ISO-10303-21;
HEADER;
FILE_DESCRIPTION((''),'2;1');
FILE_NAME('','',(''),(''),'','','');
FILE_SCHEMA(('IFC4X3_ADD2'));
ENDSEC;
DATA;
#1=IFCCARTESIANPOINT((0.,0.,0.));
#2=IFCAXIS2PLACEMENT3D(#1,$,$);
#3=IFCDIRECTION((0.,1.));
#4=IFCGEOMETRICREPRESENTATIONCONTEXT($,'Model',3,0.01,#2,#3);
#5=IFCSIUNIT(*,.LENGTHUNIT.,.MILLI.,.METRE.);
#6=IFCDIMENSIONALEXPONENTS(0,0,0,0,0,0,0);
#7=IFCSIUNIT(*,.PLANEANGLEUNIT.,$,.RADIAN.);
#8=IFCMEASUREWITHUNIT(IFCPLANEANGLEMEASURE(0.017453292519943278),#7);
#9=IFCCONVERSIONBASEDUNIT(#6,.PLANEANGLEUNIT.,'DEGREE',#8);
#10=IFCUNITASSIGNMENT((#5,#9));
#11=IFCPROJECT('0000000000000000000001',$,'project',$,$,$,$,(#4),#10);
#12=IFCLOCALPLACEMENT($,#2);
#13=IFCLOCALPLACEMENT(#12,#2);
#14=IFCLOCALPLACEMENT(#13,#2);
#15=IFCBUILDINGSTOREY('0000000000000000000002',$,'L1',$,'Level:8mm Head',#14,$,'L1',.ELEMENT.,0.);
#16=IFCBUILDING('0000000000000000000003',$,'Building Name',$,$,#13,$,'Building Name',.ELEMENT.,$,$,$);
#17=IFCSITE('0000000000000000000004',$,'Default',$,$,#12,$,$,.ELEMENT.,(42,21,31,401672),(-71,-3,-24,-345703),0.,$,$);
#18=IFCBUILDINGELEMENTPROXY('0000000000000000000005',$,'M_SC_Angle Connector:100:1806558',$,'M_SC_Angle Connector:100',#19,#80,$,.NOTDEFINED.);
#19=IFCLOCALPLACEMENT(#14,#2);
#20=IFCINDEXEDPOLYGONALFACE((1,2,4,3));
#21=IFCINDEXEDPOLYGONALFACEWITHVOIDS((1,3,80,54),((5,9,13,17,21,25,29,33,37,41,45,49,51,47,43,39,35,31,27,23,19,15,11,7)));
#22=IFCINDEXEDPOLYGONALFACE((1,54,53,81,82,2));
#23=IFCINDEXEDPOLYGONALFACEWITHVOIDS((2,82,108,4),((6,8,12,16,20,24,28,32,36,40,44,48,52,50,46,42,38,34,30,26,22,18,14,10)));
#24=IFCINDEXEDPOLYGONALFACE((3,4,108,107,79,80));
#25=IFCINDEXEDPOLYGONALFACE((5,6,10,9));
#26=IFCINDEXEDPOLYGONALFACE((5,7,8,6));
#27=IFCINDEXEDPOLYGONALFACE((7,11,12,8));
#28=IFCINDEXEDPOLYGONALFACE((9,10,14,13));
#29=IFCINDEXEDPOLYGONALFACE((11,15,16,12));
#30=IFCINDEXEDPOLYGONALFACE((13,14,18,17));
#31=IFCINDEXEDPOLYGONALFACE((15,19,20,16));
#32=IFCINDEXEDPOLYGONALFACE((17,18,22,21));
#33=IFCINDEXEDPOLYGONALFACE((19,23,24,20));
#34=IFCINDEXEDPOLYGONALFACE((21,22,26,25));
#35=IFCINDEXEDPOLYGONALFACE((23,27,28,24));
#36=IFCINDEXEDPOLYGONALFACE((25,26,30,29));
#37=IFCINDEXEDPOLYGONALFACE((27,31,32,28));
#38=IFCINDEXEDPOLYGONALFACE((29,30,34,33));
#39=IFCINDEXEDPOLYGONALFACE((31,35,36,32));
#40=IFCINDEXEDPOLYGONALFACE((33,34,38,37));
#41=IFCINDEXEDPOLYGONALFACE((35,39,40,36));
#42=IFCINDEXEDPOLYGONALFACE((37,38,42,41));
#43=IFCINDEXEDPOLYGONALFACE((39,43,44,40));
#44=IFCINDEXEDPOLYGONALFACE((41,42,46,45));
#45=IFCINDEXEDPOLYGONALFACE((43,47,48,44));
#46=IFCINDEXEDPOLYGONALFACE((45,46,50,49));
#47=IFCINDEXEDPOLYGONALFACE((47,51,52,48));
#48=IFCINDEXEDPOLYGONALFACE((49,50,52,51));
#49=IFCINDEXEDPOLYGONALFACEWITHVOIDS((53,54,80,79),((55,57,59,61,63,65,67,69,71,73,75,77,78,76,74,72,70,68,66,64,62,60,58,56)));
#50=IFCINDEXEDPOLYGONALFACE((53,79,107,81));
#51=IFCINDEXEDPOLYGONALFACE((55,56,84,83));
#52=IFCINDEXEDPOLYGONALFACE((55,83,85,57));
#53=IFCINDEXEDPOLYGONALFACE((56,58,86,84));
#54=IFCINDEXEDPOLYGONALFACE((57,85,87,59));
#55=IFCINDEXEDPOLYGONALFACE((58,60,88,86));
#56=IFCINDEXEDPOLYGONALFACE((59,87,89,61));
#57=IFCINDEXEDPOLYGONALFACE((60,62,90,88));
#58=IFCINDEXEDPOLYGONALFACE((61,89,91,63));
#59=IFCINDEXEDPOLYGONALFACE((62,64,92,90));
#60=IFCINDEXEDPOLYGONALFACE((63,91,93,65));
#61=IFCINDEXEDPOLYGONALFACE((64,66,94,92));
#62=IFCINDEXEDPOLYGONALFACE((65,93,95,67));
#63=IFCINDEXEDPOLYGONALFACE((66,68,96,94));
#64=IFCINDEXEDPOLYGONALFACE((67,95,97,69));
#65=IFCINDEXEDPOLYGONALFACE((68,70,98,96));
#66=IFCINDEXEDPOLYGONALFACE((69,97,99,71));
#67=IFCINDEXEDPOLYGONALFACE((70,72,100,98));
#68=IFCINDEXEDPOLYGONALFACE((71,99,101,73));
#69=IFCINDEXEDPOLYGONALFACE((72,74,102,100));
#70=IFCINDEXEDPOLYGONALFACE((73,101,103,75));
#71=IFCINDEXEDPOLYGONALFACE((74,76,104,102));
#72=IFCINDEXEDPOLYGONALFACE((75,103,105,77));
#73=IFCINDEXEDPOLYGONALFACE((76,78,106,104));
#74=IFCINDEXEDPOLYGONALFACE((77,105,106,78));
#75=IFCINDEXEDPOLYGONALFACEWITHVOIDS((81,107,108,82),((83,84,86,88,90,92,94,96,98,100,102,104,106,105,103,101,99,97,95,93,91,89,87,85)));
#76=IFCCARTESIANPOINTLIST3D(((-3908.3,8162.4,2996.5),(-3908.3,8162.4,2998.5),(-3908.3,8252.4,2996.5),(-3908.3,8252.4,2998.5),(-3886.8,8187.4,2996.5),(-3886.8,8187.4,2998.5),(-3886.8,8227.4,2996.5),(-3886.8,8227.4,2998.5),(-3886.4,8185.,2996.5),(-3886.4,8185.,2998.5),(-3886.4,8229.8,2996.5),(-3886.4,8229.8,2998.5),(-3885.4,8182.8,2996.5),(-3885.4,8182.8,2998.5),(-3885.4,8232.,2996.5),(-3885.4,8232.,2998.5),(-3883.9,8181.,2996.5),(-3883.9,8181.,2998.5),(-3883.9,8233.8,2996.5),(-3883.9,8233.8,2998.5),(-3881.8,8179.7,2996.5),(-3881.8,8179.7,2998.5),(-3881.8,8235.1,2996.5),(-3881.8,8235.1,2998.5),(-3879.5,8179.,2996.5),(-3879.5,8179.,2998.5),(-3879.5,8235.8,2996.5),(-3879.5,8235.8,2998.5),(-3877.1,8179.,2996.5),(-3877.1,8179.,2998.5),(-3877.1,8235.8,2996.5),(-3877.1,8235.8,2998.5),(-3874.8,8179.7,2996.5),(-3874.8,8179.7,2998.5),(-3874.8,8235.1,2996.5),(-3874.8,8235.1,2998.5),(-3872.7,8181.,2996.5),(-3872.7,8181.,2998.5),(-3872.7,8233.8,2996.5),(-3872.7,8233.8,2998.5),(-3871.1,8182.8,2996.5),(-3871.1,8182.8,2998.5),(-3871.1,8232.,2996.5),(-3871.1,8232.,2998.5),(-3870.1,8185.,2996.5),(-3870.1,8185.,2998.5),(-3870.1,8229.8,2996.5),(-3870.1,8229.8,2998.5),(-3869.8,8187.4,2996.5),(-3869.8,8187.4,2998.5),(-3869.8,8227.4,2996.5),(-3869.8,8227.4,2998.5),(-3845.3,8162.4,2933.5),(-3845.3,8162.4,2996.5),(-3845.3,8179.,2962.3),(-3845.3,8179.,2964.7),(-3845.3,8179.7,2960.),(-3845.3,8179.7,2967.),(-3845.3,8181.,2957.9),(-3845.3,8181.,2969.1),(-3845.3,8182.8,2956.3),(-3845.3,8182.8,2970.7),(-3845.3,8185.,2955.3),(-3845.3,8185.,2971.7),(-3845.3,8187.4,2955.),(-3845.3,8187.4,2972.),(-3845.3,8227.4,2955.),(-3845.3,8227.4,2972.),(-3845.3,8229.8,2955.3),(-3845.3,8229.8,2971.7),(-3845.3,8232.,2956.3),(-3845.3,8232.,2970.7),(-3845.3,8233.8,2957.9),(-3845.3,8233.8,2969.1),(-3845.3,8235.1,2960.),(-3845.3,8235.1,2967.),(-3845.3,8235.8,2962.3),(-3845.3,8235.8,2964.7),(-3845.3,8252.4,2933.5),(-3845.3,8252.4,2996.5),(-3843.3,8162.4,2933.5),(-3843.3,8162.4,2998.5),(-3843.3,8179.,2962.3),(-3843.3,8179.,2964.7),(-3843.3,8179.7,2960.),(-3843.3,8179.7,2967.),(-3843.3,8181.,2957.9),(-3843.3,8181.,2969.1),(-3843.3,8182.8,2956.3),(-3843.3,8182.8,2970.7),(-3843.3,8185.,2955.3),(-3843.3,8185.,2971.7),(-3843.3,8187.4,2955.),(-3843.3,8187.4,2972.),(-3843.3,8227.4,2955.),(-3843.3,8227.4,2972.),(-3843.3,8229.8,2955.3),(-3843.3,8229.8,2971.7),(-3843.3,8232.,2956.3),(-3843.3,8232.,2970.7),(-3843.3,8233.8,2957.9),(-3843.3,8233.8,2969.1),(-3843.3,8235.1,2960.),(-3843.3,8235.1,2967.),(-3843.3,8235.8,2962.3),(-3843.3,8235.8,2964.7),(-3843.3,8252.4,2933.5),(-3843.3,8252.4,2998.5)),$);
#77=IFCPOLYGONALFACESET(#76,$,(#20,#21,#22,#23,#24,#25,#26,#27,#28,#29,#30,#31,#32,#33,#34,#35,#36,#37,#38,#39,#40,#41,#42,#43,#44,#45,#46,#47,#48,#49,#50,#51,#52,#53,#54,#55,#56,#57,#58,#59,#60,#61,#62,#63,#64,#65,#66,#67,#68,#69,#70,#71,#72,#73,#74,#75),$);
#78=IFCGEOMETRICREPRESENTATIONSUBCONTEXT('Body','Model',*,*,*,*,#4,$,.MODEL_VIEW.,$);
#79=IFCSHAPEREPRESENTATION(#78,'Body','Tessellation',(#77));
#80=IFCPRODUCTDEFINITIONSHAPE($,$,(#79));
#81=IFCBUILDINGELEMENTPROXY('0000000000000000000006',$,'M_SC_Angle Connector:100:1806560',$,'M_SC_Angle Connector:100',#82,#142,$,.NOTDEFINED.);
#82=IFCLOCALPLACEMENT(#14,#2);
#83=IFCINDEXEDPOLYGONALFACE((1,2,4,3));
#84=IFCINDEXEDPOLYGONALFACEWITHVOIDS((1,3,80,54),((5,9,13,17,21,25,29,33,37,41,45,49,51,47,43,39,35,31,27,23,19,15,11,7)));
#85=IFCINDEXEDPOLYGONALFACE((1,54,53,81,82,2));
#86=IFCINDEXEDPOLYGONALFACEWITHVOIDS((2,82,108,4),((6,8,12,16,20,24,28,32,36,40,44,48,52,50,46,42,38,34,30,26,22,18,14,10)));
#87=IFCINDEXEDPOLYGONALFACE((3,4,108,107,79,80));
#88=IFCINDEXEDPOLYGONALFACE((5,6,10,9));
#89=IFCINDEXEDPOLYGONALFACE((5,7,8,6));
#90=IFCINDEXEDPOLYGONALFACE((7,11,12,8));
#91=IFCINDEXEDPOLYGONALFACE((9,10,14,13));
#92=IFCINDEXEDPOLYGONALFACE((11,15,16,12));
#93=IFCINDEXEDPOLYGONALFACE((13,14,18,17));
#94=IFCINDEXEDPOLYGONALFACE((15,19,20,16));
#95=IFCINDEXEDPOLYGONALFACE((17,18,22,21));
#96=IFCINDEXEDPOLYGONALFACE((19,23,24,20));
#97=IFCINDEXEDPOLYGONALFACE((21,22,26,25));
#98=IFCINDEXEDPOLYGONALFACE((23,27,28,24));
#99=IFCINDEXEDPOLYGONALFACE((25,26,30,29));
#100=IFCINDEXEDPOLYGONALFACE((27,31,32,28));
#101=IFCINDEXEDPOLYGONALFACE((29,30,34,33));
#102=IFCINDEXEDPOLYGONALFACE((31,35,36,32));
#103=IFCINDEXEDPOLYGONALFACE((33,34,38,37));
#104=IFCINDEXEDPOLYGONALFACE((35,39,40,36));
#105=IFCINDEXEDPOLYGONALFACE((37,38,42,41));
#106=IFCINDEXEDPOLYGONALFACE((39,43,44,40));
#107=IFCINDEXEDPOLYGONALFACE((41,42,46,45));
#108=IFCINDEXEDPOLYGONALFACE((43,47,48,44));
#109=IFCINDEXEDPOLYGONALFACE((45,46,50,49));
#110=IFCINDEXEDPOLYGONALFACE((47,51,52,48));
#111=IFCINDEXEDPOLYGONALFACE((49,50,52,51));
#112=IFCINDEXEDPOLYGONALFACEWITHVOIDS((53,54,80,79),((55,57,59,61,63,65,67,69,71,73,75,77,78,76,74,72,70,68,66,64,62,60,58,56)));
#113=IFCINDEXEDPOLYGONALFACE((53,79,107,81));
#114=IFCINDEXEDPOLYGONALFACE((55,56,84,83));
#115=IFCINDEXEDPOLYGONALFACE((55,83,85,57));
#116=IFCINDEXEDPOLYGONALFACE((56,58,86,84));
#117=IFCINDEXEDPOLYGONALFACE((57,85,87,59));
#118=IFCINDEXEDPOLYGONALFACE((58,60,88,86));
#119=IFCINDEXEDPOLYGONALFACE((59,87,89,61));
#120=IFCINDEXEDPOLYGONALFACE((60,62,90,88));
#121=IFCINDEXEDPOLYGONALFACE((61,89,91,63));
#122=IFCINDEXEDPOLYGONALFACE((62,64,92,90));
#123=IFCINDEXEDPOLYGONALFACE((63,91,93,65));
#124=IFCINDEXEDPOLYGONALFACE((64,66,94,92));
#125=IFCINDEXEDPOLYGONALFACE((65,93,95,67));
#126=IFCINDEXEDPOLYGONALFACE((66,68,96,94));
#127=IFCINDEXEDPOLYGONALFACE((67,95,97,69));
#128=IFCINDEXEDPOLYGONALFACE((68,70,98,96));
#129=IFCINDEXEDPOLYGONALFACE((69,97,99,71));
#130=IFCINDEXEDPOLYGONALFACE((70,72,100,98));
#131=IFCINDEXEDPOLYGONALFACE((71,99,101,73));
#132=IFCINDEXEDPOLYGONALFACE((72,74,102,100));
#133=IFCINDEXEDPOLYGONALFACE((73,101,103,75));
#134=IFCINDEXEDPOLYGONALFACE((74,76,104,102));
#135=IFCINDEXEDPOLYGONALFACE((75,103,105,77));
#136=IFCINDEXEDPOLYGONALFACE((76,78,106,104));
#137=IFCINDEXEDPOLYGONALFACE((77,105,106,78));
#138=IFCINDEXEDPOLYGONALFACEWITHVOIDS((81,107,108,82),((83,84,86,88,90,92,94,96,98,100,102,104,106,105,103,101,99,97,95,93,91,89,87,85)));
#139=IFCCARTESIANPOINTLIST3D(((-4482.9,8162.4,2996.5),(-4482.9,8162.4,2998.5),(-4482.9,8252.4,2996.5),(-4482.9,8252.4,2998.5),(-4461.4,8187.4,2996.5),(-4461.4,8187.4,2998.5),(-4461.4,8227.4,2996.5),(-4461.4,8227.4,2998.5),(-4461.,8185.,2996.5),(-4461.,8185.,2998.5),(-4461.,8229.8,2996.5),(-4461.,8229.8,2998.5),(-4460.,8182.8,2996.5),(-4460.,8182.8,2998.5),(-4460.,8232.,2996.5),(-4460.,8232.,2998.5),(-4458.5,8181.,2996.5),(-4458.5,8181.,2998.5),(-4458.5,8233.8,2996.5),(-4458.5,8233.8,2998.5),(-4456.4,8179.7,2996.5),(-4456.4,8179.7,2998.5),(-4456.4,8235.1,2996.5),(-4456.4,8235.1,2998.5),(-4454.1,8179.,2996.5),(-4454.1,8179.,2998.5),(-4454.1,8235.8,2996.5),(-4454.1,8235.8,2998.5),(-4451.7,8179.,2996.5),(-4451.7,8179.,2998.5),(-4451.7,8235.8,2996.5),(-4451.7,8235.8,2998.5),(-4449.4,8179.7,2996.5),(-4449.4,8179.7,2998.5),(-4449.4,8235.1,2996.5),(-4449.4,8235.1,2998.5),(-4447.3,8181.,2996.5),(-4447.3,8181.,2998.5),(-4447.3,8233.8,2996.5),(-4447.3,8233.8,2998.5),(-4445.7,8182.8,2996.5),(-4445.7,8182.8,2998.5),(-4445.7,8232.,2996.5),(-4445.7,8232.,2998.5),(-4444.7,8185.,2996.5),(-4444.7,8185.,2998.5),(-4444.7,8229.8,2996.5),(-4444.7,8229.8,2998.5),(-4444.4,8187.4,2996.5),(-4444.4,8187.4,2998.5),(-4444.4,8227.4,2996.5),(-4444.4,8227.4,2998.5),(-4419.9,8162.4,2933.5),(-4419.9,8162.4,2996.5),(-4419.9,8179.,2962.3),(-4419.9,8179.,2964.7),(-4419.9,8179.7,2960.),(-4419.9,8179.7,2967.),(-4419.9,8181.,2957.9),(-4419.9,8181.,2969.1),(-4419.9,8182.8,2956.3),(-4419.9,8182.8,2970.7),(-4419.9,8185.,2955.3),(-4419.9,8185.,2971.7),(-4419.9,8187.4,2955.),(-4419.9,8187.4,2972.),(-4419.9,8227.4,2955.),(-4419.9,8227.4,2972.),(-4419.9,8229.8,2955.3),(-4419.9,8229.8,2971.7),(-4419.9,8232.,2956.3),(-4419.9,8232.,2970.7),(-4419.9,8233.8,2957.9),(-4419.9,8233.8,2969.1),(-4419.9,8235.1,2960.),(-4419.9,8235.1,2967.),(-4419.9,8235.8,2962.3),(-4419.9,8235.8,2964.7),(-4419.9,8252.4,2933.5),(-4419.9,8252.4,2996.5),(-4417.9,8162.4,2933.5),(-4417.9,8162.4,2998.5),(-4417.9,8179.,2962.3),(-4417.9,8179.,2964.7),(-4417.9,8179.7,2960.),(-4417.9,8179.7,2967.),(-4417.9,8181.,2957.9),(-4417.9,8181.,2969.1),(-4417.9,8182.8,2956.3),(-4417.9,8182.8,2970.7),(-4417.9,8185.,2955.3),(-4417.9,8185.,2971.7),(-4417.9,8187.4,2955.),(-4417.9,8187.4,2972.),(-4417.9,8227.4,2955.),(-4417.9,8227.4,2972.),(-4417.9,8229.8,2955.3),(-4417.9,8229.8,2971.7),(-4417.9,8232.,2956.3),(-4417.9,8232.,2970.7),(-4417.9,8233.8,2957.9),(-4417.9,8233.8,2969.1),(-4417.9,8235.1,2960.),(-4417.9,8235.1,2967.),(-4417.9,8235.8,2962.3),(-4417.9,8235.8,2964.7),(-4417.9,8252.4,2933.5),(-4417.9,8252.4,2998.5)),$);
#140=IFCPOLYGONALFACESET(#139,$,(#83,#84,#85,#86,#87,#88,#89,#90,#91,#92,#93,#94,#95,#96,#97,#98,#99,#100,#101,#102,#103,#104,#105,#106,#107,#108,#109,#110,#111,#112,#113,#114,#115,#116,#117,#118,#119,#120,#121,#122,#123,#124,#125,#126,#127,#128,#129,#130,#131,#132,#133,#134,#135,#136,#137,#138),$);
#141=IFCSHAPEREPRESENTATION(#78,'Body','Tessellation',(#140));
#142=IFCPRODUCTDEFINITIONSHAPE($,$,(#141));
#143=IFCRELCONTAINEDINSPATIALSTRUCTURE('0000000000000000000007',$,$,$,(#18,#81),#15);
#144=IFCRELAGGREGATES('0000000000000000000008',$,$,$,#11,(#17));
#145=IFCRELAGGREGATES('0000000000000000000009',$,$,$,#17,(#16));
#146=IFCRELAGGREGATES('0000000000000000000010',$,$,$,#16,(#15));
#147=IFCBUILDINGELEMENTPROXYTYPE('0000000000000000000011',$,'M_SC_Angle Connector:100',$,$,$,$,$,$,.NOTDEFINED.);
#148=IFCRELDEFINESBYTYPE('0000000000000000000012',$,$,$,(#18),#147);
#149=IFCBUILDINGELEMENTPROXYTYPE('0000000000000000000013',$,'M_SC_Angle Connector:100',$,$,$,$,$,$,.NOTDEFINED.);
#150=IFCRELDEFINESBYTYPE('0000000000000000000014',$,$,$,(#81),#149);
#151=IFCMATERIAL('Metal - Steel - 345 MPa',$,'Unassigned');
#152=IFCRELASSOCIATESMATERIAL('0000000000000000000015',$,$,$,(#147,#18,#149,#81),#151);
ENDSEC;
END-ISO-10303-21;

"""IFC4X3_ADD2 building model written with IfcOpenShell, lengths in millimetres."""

from ifc_helpers import new_model, entity, si_unit, converted_unit, direction, frame, frame_2d, origin, place, context, subcontext, project, spatial, polyline, circle_curve, parameter, trimmed, segment, composite_curve, outline, extrude, source, transform, mapped, material, type_object, type_shapes, element, save


model = new_model("IFC4X3_ADD2")

# Units and contexts
model_context = context("Model", 3, precision=0.01, world=origin(), true_north=direction((0.0, 1.0)))
body_context = subcontext(model_context, "Body", "Model", "MODEL_VIEW")
ifc_project = project(units=[si_unit("LENGTHUNIT", "METRE", prefix="MILLI"), converted_unit("PLANEANGLEUNIT", "DEGREE", entity("IfcPlaneAngleMeasure", 0.017453292519943278), si_unit("PLANEANGLEUNIT", "RADIAN"), dimensions=[0, 0, 0, 0, 0, 0, 0])], contexts=[model_context])

# Site, building, storey
site_placement = place(None, origin())
site = spatial("IfcSite", under=ifc_project, at=site_placement, Name="Default", CompositionType="ELEMENT", RefLatitude=(42, 21, 31, 401672), RefLongitude=(-71, -3, -24, -345703), RefElevation=0.0)
building_placement = place(site_placement, origin())
building = spatial("IfcBuilding", under=site, at=building_placement, Name="Building Name", LongName="Building Name", CompositionType="ELEMENT")
storey_placement = place(building_placement, origin())
storey = spatial("IfcBuildingStorey", under=building, at=storey_placement, Name="L1", ObjectType="Level:8mm Head", LongName="L1", CompositionType="ELEMENT", Elevation=0.0)

# Building element proxies, openings
ifc_material_1 = material(Name="Metal - Steel - 345 MPa", Category="Unassigned")
building_element_proxy_type_1 = type_object("IfcBuildingElementProxyType", Name="M_SC_Angle Connector:100", PredefinedType="NOTDEFINED", material=ifc_material_1)
shared_shape_1 = source(origin(), body_context, "Body", "SweptSolid", [
    extrude(outline(polyline([(-42.7, -22.3), (22.3, -22.3), (22.3, 42.7), (20.3, 42.7), (20.3, -20.3), (-42.7, -20.3), (-42.7, -22.3)])), frame((22.3, -45.0, 22.3), z_axis=(0.0, 1.0, 0.0), x_axis=(-1.0, 0.0, 0.0)), (0.0, 0.0, 1.0), 90.0),
])
type_shapes(building_element_proxy_type_1, [shared_shape_1])
proxy_1_placement = place(storey_placement, frame((-3843.3, 8207.4, 2998.5), z_axis=(0.0, 0.0, -1.0), x_axis=(-1.0, 0.0, 0.0)))
proxy_1 = element("IfcBuildingElementProxy", 1, at=proxy_1_placement, inside=storey, type_object=building_element_proxy_type_1, material=ifc_material_1, Name="M_SC_Angle Connector:100:1806558", ObjectType="M_SC_Angle Connector:100", PredefinedType="NOTDEFINED", context=body_context, shape_type="MappedRepresentation", body=[
    mapped(shared_shape_1, transform((0.0, 0.0, 0.0), scale=1.0)),
])
opening_1_placement = place(storey_placement, frame((-3843.3, 8207.4, 2998.5)))
element("IfcOpeningElement", 2, at=opening_1_placement, cuts=proxy_1, PredefinedType="OPENING", context=body_context, shape_type="SweptSolid", body=[
    extrude(outline(composite_curve([segment(trimmed(circle_curve(frame_2d((0.0, -20.0), x_axis=(1.0, 0.0)), 8.5), [parameter(180.0)], [parameter(0.0)], True, "PARAMETER"), True, "CONTINUOUS"), segment(polyline([(8.5, -20.0), (8.5, 20.0)]), True, "CONTINUOUS"), segment(trimmed(circle_curve(frame_2d((0.0, 20.0), x_axis=(1.0, 0.0)), 8.5), [parameter(0.0)], [parameter(180.0)], True, "PARAMETER"), True, "CONTINUOUS"), segment(polyline([(-8.5, 20.0), (-8.5, -20.0)]), True, "CONTINUOUS")], self_intersect=False)), frame((-2.0, 0.0, -35.0), z_axis=(1.0, 0.0, 0.0), x_axis=(0.0, 0.0, -1.0)), (0.0, 0.0, 1.0), 2.0),
])
opening_2_placement = place(storey_placement, frame((-3843.3, 8207.4, 2998.5)))
element("IfcOpeningElement", 3, at=opening_2_placement, cuts=proxy_1, PredefinedType="OPENING", context=body_context, shape_type="SweptSolid", body=[
    extrude(outline(composite_curve([segment(trimmed(circle_curve(frame_2d((0.0, 20.0), x_axis=(1.0, 0.0)), 8.5), [parameter(0.0)], [parameter(180.0)], True, "PARAMETER"), True, "CONTINUOUS"), segment(polyline([(-8.5, 20.0), (-8.5, -20.0)]), True, "CONTINUOUS"), segment(trimmed(circle_curve(frame_2d((0.0, -20.0), x_axis=(1.0, 0.0)), 8.5), [parameter(180.0)], [parameter(0.0)], True, "PARAMETER"), True, "CONTINUOUS"), segment(polyline([(8.5, -20.0), (8.5, 20.0)]), True, "CONTINUOUS")], self_intersect=False)), frame((-35.0, 0.0, -2.0), z_axis=(0.0, 0.0, 1.0), x_axis=(-1.0, 0.0, 0.0)), (0.0, 0.0, 1.0), 2.0),
])
building_element_proxy_type_2 = type_object("IfcBuildingElementProxyType", Name="M_SC_Angle Connector:100", PredefinedType="NOTDEFINED", material=ifc_material_1)
shared_shape_2 = source(origin(), body_context, "Body", "SweptSolid", [
    extrude(outline(polyline([(-42.7, -22.3), (22.3, -22.3), (22.3, 42.7), (20.3, 42.7), (20.3, -20.3), (-42.7, -20.3), (-42.7, -22.3)])), frame((22.3, -45.0, 22.3), z_axis=(0.0, 1.0, 0.0), x_axis=(-1.0, 0.0, 0.0)), (0.0, 0.0, 1.0), 90.0),
])
type_shapes(building_element_proxy_type_2, [shared_shape_2])
proxy_2_placement = place(storey_placement, frame((-4417.9, 8207.4, 2998.5), z_axis=(0.0, 0.0, -1.0), x_axis=(-1.0, 0.0, 0.0)))
proxy_2 = element("IfcBuildingElementProxy", 4, at=proxy_2_placement, inside=storey, type_object=building_element_proxy_type_2, material=ifc_material_1, Name="M_SC_Angle Connector:100:1806560", ObjectType="M_SC_Angle Connector:100", PredefinedType="NOTDEFINED", context=body_context, shape_type="MappedRepresentation", body=[
    mapped(shared_shape_2, transform((0.0, 0.0, 0.0), scale=1.0)),
])
opening_3_placement = place(storey_placement, frame((-4417.9, 8207.4, 2998.5)))
element("IfcOpeningElement", 5, at=opening_3_placement, cuts=proxy_2, PredefinedType="OPENING", context=body_context, shape_type="SweptSolid", body=[
    extrude(outline(composite_curve([segment(trimmed(circle_curve(frame_2d((0.0, -20.0), x_axis=(1.0, 0.0)), 8.5), [parameter(180.0)], [parameter(0.0)], True, "PARAMETER"), True, "CONTINUOUS"), segment(polyline([(8.5, -20.0), (8.5, 20.0)]), True, "CONTINUOUS"), segment(trimmed(circle_curve(frame_2d((0.0, 20.0), x_axis=(1.0, 0.0)), 8.5), [parameter(0.0)], [parameter(180.0)], True, "PARAMETER"), True, "CONTINUOUS"), segment(polyline([(-8.5, 20.0), (-8.5, -20.0)]), True, "CONTINUOUS")], self_intersect=False)), frame((-2.0, 0.0, -35.0), z_axis=(1.0, 0.0, 0.0), x_axis=(0.0, 0.0, -1.0)), (0.0, 0.0, 1.0), 2.0),
])
opening_4_placement = place(storey_placement, frame((-4417.9, 8207.4, 2998.5)))
element("IfcOpeningElement", 6, at=opening_4_placement, cuts=proxy_2, PredefinedType="OPENING", context=body_context, shape_type="SweptSolid", body=[
    extrude(outline(composite_curve([segment(trimmed(circle_curve(frame_2d((0.0, 20.0), x_axis=(1.0, 0.0)), 8.5), [parameter(0.0)], [parameter(180.0)], True, "PARAMETER"), True, "CONTINUOUS"), segment(polyline([(-8.5, 20.0), (-8.5, -20.0)]), True, "CONTINUOUS"), segment(trimmed(circle_curve(frame_2d((0.0, -20.0), x_axis=(1.0, 0.0)), 8.5), [parameter(180.0)], [parameter(0.0)], True, "PARAMETER"), True, "CONTINUOUS"), segment(polyline([(8.5, -20.0), (8.5, 20.0)]), True, "CONTINUOUS")], self_intersect=False)), frame((-35.0, 0.0, -2.0), z_axis=(0.0, 0.0, 1.0), x_axis=(-1.0, 0.0, 0.0)), (0.0, 0.0, 1.0), 2.0),
])

save(model, "model.ifc")
